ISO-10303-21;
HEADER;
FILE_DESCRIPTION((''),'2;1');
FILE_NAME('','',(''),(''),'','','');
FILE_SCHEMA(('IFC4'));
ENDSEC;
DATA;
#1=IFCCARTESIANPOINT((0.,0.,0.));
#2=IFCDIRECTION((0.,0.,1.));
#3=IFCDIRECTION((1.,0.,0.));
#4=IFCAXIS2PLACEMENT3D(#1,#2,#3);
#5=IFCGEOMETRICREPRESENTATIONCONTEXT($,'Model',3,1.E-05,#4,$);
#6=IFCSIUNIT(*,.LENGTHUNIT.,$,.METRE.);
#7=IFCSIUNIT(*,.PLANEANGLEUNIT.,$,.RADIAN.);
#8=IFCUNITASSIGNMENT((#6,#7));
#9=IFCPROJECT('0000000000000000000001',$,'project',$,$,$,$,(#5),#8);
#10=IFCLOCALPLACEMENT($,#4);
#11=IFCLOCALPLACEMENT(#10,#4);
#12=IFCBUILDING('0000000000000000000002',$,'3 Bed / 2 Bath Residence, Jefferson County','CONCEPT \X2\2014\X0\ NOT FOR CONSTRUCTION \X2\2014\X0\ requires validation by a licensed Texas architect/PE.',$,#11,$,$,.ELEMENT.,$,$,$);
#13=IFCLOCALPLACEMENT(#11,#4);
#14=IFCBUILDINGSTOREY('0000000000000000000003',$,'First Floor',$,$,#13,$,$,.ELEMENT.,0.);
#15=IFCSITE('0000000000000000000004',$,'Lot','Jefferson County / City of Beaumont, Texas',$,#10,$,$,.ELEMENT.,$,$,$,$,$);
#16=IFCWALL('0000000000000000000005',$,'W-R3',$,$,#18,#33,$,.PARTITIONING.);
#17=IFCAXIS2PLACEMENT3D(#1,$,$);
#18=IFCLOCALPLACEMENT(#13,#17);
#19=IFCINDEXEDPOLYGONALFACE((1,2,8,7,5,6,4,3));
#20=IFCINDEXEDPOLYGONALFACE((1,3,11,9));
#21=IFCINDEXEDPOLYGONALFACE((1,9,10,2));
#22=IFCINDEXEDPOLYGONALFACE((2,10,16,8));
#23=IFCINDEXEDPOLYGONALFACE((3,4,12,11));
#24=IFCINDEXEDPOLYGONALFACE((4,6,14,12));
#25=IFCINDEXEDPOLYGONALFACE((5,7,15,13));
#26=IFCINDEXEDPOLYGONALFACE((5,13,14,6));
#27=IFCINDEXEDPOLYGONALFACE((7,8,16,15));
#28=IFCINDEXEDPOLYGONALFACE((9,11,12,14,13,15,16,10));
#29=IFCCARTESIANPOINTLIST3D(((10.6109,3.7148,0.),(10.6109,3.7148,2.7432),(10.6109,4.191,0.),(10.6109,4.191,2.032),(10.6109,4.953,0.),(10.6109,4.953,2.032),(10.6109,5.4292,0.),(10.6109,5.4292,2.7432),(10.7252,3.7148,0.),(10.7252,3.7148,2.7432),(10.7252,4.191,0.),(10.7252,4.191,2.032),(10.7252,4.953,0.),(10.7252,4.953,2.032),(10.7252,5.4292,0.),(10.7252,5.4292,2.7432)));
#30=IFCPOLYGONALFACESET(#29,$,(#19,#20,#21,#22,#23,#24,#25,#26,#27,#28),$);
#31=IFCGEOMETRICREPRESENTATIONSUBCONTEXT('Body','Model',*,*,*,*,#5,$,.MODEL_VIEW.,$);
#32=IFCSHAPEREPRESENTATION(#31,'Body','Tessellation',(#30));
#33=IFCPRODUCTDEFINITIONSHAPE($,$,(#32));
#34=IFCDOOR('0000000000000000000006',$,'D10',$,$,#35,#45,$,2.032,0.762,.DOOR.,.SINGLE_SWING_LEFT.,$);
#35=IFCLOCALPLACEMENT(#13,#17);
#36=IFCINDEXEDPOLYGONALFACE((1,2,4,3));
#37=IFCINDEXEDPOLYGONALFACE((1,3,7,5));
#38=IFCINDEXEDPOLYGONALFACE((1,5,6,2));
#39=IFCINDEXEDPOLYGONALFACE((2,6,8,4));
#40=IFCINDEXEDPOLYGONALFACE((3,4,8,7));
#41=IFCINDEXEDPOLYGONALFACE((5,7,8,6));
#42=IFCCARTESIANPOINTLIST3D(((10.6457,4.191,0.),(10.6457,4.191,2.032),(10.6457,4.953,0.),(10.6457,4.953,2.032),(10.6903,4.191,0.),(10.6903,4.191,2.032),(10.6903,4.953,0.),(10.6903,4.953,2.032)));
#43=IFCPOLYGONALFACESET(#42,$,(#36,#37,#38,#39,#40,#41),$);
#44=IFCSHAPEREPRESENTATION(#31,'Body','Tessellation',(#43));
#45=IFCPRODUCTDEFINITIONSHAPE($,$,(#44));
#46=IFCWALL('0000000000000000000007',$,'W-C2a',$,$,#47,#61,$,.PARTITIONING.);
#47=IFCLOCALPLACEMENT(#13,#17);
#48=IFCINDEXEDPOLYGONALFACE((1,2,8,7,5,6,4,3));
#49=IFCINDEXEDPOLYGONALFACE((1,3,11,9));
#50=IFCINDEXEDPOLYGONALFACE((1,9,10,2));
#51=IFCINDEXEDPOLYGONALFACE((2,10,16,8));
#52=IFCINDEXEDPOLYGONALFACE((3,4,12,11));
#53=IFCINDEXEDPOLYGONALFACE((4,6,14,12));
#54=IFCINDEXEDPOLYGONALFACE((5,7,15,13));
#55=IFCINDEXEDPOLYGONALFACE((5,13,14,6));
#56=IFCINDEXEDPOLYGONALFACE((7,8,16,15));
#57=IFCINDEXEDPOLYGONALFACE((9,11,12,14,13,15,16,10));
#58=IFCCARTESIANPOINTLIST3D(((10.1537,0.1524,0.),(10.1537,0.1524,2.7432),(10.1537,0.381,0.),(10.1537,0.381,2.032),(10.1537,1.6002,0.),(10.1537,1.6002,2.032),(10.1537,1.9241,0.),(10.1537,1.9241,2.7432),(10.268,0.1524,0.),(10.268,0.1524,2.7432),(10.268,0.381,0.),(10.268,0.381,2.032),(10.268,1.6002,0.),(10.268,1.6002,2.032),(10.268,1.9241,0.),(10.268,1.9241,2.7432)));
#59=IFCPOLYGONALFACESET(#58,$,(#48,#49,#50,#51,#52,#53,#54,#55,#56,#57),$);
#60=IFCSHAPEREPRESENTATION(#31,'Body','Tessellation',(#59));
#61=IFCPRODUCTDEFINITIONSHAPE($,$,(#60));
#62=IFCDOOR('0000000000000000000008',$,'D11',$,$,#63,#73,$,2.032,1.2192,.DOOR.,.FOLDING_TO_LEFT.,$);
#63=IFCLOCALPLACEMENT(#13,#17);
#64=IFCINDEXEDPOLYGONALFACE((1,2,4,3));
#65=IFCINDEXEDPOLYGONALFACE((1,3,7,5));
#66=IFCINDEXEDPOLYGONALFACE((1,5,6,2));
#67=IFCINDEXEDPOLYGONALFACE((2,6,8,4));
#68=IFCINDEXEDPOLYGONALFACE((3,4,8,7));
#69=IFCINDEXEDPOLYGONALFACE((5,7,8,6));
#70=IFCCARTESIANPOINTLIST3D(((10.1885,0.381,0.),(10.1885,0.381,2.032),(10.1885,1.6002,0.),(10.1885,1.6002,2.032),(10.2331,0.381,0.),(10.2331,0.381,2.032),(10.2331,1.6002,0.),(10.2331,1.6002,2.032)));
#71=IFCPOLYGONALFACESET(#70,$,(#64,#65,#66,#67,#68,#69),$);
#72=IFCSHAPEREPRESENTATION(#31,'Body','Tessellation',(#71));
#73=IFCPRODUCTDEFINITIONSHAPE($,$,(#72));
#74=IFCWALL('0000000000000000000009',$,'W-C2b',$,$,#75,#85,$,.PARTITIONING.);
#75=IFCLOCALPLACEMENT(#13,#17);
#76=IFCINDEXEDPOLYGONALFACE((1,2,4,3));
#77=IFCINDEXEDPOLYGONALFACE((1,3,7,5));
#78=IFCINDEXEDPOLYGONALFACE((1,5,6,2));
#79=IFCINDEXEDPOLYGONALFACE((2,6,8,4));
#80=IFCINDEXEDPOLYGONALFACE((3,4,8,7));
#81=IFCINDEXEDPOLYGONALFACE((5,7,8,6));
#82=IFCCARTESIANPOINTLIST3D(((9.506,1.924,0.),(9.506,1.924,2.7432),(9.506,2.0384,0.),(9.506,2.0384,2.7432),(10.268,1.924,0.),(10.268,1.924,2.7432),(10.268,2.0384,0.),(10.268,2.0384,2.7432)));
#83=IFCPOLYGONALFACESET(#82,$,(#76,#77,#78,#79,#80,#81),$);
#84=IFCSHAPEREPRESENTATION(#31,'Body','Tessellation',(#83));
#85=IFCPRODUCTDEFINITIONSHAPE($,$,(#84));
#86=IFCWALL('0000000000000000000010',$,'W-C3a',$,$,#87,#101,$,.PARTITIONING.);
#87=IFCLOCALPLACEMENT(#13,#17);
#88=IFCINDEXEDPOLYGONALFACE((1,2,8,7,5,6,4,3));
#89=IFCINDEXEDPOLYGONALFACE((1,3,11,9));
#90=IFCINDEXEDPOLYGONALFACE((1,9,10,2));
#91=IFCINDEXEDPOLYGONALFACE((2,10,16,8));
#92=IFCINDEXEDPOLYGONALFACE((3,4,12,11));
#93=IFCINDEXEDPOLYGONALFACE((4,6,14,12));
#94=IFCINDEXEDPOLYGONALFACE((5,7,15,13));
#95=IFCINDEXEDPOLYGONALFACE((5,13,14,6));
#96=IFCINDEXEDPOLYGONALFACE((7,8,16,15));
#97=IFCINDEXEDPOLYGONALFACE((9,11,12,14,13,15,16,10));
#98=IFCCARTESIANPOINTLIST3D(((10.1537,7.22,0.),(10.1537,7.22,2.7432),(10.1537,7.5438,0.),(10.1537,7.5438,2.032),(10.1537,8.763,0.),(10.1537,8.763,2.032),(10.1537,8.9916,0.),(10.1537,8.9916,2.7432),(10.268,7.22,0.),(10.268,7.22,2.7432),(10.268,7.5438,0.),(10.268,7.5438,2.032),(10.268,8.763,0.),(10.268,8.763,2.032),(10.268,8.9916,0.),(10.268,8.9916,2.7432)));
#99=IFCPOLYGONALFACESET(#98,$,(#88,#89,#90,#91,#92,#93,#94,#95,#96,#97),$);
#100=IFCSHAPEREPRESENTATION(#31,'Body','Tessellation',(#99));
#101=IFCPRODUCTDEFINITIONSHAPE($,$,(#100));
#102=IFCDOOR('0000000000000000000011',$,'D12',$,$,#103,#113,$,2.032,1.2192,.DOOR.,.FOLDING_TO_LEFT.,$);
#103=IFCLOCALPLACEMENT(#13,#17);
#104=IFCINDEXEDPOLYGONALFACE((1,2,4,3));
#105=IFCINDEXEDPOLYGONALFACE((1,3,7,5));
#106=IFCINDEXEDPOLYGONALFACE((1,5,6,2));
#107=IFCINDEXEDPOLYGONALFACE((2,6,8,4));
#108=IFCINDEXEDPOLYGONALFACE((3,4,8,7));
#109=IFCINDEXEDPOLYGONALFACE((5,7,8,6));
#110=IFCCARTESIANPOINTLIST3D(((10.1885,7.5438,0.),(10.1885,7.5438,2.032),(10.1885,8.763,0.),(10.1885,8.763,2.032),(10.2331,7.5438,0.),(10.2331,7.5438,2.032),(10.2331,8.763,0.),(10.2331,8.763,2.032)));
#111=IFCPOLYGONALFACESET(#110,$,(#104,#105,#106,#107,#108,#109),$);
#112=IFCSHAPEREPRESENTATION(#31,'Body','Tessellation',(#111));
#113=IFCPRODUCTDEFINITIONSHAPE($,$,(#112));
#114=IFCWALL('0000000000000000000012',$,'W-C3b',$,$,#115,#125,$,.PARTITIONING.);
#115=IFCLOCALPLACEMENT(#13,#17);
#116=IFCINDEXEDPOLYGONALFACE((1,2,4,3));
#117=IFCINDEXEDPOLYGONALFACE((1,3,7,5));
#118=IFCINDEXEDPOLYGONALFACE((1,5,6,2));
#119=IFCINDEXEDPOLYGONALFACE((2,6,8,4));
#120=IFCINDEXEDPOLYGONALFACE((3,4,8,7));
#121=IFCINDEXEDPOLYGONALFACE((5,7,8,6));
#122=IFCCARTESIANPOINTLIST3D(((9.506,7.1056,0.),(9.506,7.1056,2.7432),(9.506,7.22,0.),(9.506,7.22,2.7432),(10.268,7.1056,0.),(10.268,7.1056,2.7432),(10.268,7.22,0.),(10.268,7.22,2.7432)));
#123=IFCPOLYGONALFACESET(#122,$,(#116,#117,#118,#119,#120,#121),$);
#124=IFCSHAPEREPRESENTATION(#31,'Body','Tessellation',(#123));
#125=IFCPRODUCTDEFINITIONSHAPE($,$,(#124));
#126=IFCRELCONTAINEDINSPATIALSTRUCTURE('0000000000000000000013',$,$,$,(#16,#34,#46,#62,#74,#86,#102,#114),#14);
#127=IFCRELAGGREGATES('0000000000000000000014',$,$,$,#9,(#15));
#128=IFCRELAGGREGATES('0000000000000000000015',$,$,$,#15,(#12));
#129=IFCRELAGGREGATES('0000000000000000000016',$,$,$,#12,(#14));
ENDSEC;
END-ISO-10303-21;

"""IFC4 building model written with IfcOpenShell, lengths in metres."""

from ifc_helpers import new_model, si_unit, frame, frame_2d, origin_with_axes, place, context, subcontext, project, spatial, rectangle, extrude, element, fill, save


model = new_model("IFC4")

# Units and contexts
model_context = context("Model", 3, precision=1e-05, world=origin_with_axes())
body_context = subcontext(model_context, "Body", "Model", "MODEL_VIEW")
ifc_project = project(units=[si_unit("LENGTHUNIT", "METRE"), si_unit("PLANEANGLEUNIT", "RADIAN")], contexts=[model_context])

# Site, building, storey
site_placement = place(None, origin_with_axes())
site = spatial("IfcSite", under=ifc_project, at=site_placement, Name="Lot", Description="Jefferson County / City of Beaumont, Texas", CompositionType="ELEMENT")
building_placement = place(site_placement, origin_with_axes())
building = spatial("IfcBuilding", under=site, at=building_placement, Name="3 Bed / 2 Bath Residence, Jefferson County", Description="CONCEPT — NOT FOR CONSTRUCTION — requires validation by a licensed Texas architect/PE.", CompositionType="ELEMENT")
storey_placement = place(building_placement, origin_with_axes())
storey = spatial("IfcBuildingStorey", under=building, at=storey_placement, Name="First Floor", CompositionType="ELEMENT", Elevation=0.0)

# Walls, openings, doors
wall_1_placement = place(storey_placement, frame((10.668, 3.7147, 0.0), z_axis=(0.0, 0.0, 1.0), x_axis=(0.0, 1.0, 0.0)))
wall_1 = element("IfcWall", 1, at=wall_1_placement, inside=storey, Name="W-R3", PredefinedType="PARTITIONING", context=body_context, shape_type="SweptSolid", body=[
    extrude(rectangle(XDim=1.7145, YDim=0.1143, at=frame_2d((0.8573, 0.0), x_axis=(1.0, 0.0))), origin_with_axes(), (0.0, 0.0, 1.0), 2.7432),
])
opening_1_placement = place(wall_1_placement, frame((0.4763, 0.0, 0.0), z_axis=(0.0, 0.0, 1.0), x_axis=(1.0, 0.0, 0.0)))
opening_1 = element("IfcOpeningElement", 2, at=opening_1_placement, cuts=wall_1, PredefinedType="OPENING", context=body_context, shape_type="SweptSolid", body=[
    extrude(rectangle(XDim=0.762, YDim=0.1448, at=frame_2d((0.381, 0.0), x_axis=(1.0, 0.0))), origin_with_axes(), (0.0, 0.0, 1.0), 2.032),
])
door_1_placement = place(opening_1_placement, origin_with_axes())
door_1 = element("IfcDoor", 3, at=door_1_placement, inside=storey, Name="D10", OperationType="SINGLE_SWING_LEFT", OverallHeight=2.032, OverallWidth=0.762, PredefinedType="DOOR", context=body_context, shape_type="SweptSolid", body=[
    extrude(rectangle(XDim=0.762, YDim=0.0445, at=frame_2d((0.381, 0.0), x_axis=(1.0, 0.0))), origin_with_axes(), (0.0, 0.0, 1.0), 2.032),
])
fill(opening_1, door_1)
wall_2_placement = place(storey_placement, frame((10.2108, 0.1524, 0.0), z_axis=(0.0, 0.0, 1.0), x_axis=(0.0, 1.0, 0.0)))
wall_2 = element("IfcWall", 4, at=wall_2_placement, inside=storey, Name="W-C2a", PredefinedType="PARTITIONING", context=body_context, shape_type="SweptSolid", body=[
    extrude(rectangle(XDim=1.7717, YDim=0.1143, at=frame_2d((0.8858, 0.0), x_axis=(1.0, 0.0))), origin_with_axes(), (0.0, 0.0, 1.0), 2.7432),
])
opening_2_placement = place(wall_2_placement, frame((0.2286, 0.0, 0.0), z_axis=(0.0, 0.0, 1.0), x_axis=(1.0, 0.0, 0.0)))
opening_2 = element("IfcOpeningElement", 5, at=opening_2_placement, cuts=wall_2, PredefinedType="OPENING", context=body_context, shape_type="SweptSolid", body=[
    extrude(rectangle(XDim=1.2192, YDim=0.1448, at=frame_2d((0.6096, 0.0), x_axis=(1.0, 0.0))), origin_with_axes(), (0.0, 0.0, 1.0), 2.032),
])
door_2_placement = place(opening_2_placement, origin_with_axes())
door_2 = element("IfcDoor", 6, at=door_2_placement, inside=storey, Name="D11", OperationType="FOLDING_TO_LEFT", OverallHeight=2.032, OverallWidth=1.2192, PredefinedType="DOOR", context=body_context, shape_type="SweptSolid", body=[
    extrude(rectangle(XDim=1.2192, YDim=0.0445, at=frame_2d((0.6096, 0.0), x_axis=(1.0, 0.0))), origin_with_axes(), (0.0, 0.0, 1.0), 2.032),
])
fill(opening_2, door_2)

# Wall
wall_3_placement = place(storey_placement, frame((9.506, 1.9812, 0.0), z_axis=(0.0, 0.0, 1.0), x_axis=(1.0, 0.0, 0.0)))
element("IfcWall", 7, at=wall_3_placement, inside=storey, Name="W-C2b", PredefinedType="PARTITIONING", context=body_context, shape_type="SweptSolid", body=[
    extrude(rectangle(XDim=0.762, YDim=0.1143, at=frame_2d((0.381, 0.0), x_axis=(1.0, 0.0))), origin_with_axes(), (0.0, 0.0, 1.0), 2.7432),
])

# Wall, opening, door
wall_4_placement = place(storey_placement, frame((10.2108, 7.22, 0.0), z_axis=(0.0, 0.0, 1.0), x_axis=(0.0, 1.0, 0.0)))
wall_4 = element("IfcWall", 8, at=wall_4_placement, inside=storey, Name="W-C3a", PredefinedType="PARTITIONING", context=body_context, shape_type="SweptSolid", body=[
    extrude(rectangle(XDim=1.7717, YDim=0.1143, at=frame_2d((0.8858, 0.0), x_axis=(1.0, 0.0))), origin_with_axes(), (0.0, 0.0, 1.0), 2.7432),
])
opening_3_placement = place(wall_4_placement, frame((0.3239, 0.0, 0.0), z_axis=(0.0, 0.0, 1.0), x_axis=(1.0, 0.0, 0.0)))
opening_3 = element("IfcOpeningElement", 9, at=opening_3_placement, cuts=wall_4, PredefinedType="OPENING", context=body_context, shape_type="SweptSolid", body=[
    extrude(rectangle(XDim=1.2192, YDim=0.1448, at=frame_2d((0.6096, 0.0), x_axis=(1.0, 0.0))), origin_with_axes(), (0.0, 0.0, 1.0), 2.032),
])
door_3_placement = place(opening_3_placement, origin_with_axes())
door_3 = element("IfcDoor", 10, at=door_3_placement, inside=storey, Name="D12", OperationType="FOLDING_TO_LEFT", OverallHeight=2.032, OverallWidth=1.2192, PredefinedType="DOOR", context=body_context, shape_type="SweptSolid", body=[
    extrude(rectangle(XDim=1.2192, YDim=0.0445, at=frame_2d((0.6096, 0.0), x_axis=(1.0, 0.0))), origin_with_axes(), (0.0, 0.0, 1.0), 2.032),
])
fill(opening_3, door_3)

# Wall
wall_5_placement = place(storey_placement, frame((9.506, 7.1628, 0.0), z_axis=(0.0, 0.0, 1.0), x_axis=(1.0, 0.0, 0.0)))
element("IfcWall", 11, at=wall_5_placement, inside=storey, Name="W-C3b", PredefinedType="PARTITIONING", context=body_context, shape_type="SweptSolid", body=[
    extrude(rectangle(XDim=0.762, YDim=0.1143, at=frame_2d((0.381, 0.0), x_axis=(1.0, 0.0))), origin_with_axes(), (0.0, 0.0, 1.0), 2.7432),
])

save(model, "model.ifc")
